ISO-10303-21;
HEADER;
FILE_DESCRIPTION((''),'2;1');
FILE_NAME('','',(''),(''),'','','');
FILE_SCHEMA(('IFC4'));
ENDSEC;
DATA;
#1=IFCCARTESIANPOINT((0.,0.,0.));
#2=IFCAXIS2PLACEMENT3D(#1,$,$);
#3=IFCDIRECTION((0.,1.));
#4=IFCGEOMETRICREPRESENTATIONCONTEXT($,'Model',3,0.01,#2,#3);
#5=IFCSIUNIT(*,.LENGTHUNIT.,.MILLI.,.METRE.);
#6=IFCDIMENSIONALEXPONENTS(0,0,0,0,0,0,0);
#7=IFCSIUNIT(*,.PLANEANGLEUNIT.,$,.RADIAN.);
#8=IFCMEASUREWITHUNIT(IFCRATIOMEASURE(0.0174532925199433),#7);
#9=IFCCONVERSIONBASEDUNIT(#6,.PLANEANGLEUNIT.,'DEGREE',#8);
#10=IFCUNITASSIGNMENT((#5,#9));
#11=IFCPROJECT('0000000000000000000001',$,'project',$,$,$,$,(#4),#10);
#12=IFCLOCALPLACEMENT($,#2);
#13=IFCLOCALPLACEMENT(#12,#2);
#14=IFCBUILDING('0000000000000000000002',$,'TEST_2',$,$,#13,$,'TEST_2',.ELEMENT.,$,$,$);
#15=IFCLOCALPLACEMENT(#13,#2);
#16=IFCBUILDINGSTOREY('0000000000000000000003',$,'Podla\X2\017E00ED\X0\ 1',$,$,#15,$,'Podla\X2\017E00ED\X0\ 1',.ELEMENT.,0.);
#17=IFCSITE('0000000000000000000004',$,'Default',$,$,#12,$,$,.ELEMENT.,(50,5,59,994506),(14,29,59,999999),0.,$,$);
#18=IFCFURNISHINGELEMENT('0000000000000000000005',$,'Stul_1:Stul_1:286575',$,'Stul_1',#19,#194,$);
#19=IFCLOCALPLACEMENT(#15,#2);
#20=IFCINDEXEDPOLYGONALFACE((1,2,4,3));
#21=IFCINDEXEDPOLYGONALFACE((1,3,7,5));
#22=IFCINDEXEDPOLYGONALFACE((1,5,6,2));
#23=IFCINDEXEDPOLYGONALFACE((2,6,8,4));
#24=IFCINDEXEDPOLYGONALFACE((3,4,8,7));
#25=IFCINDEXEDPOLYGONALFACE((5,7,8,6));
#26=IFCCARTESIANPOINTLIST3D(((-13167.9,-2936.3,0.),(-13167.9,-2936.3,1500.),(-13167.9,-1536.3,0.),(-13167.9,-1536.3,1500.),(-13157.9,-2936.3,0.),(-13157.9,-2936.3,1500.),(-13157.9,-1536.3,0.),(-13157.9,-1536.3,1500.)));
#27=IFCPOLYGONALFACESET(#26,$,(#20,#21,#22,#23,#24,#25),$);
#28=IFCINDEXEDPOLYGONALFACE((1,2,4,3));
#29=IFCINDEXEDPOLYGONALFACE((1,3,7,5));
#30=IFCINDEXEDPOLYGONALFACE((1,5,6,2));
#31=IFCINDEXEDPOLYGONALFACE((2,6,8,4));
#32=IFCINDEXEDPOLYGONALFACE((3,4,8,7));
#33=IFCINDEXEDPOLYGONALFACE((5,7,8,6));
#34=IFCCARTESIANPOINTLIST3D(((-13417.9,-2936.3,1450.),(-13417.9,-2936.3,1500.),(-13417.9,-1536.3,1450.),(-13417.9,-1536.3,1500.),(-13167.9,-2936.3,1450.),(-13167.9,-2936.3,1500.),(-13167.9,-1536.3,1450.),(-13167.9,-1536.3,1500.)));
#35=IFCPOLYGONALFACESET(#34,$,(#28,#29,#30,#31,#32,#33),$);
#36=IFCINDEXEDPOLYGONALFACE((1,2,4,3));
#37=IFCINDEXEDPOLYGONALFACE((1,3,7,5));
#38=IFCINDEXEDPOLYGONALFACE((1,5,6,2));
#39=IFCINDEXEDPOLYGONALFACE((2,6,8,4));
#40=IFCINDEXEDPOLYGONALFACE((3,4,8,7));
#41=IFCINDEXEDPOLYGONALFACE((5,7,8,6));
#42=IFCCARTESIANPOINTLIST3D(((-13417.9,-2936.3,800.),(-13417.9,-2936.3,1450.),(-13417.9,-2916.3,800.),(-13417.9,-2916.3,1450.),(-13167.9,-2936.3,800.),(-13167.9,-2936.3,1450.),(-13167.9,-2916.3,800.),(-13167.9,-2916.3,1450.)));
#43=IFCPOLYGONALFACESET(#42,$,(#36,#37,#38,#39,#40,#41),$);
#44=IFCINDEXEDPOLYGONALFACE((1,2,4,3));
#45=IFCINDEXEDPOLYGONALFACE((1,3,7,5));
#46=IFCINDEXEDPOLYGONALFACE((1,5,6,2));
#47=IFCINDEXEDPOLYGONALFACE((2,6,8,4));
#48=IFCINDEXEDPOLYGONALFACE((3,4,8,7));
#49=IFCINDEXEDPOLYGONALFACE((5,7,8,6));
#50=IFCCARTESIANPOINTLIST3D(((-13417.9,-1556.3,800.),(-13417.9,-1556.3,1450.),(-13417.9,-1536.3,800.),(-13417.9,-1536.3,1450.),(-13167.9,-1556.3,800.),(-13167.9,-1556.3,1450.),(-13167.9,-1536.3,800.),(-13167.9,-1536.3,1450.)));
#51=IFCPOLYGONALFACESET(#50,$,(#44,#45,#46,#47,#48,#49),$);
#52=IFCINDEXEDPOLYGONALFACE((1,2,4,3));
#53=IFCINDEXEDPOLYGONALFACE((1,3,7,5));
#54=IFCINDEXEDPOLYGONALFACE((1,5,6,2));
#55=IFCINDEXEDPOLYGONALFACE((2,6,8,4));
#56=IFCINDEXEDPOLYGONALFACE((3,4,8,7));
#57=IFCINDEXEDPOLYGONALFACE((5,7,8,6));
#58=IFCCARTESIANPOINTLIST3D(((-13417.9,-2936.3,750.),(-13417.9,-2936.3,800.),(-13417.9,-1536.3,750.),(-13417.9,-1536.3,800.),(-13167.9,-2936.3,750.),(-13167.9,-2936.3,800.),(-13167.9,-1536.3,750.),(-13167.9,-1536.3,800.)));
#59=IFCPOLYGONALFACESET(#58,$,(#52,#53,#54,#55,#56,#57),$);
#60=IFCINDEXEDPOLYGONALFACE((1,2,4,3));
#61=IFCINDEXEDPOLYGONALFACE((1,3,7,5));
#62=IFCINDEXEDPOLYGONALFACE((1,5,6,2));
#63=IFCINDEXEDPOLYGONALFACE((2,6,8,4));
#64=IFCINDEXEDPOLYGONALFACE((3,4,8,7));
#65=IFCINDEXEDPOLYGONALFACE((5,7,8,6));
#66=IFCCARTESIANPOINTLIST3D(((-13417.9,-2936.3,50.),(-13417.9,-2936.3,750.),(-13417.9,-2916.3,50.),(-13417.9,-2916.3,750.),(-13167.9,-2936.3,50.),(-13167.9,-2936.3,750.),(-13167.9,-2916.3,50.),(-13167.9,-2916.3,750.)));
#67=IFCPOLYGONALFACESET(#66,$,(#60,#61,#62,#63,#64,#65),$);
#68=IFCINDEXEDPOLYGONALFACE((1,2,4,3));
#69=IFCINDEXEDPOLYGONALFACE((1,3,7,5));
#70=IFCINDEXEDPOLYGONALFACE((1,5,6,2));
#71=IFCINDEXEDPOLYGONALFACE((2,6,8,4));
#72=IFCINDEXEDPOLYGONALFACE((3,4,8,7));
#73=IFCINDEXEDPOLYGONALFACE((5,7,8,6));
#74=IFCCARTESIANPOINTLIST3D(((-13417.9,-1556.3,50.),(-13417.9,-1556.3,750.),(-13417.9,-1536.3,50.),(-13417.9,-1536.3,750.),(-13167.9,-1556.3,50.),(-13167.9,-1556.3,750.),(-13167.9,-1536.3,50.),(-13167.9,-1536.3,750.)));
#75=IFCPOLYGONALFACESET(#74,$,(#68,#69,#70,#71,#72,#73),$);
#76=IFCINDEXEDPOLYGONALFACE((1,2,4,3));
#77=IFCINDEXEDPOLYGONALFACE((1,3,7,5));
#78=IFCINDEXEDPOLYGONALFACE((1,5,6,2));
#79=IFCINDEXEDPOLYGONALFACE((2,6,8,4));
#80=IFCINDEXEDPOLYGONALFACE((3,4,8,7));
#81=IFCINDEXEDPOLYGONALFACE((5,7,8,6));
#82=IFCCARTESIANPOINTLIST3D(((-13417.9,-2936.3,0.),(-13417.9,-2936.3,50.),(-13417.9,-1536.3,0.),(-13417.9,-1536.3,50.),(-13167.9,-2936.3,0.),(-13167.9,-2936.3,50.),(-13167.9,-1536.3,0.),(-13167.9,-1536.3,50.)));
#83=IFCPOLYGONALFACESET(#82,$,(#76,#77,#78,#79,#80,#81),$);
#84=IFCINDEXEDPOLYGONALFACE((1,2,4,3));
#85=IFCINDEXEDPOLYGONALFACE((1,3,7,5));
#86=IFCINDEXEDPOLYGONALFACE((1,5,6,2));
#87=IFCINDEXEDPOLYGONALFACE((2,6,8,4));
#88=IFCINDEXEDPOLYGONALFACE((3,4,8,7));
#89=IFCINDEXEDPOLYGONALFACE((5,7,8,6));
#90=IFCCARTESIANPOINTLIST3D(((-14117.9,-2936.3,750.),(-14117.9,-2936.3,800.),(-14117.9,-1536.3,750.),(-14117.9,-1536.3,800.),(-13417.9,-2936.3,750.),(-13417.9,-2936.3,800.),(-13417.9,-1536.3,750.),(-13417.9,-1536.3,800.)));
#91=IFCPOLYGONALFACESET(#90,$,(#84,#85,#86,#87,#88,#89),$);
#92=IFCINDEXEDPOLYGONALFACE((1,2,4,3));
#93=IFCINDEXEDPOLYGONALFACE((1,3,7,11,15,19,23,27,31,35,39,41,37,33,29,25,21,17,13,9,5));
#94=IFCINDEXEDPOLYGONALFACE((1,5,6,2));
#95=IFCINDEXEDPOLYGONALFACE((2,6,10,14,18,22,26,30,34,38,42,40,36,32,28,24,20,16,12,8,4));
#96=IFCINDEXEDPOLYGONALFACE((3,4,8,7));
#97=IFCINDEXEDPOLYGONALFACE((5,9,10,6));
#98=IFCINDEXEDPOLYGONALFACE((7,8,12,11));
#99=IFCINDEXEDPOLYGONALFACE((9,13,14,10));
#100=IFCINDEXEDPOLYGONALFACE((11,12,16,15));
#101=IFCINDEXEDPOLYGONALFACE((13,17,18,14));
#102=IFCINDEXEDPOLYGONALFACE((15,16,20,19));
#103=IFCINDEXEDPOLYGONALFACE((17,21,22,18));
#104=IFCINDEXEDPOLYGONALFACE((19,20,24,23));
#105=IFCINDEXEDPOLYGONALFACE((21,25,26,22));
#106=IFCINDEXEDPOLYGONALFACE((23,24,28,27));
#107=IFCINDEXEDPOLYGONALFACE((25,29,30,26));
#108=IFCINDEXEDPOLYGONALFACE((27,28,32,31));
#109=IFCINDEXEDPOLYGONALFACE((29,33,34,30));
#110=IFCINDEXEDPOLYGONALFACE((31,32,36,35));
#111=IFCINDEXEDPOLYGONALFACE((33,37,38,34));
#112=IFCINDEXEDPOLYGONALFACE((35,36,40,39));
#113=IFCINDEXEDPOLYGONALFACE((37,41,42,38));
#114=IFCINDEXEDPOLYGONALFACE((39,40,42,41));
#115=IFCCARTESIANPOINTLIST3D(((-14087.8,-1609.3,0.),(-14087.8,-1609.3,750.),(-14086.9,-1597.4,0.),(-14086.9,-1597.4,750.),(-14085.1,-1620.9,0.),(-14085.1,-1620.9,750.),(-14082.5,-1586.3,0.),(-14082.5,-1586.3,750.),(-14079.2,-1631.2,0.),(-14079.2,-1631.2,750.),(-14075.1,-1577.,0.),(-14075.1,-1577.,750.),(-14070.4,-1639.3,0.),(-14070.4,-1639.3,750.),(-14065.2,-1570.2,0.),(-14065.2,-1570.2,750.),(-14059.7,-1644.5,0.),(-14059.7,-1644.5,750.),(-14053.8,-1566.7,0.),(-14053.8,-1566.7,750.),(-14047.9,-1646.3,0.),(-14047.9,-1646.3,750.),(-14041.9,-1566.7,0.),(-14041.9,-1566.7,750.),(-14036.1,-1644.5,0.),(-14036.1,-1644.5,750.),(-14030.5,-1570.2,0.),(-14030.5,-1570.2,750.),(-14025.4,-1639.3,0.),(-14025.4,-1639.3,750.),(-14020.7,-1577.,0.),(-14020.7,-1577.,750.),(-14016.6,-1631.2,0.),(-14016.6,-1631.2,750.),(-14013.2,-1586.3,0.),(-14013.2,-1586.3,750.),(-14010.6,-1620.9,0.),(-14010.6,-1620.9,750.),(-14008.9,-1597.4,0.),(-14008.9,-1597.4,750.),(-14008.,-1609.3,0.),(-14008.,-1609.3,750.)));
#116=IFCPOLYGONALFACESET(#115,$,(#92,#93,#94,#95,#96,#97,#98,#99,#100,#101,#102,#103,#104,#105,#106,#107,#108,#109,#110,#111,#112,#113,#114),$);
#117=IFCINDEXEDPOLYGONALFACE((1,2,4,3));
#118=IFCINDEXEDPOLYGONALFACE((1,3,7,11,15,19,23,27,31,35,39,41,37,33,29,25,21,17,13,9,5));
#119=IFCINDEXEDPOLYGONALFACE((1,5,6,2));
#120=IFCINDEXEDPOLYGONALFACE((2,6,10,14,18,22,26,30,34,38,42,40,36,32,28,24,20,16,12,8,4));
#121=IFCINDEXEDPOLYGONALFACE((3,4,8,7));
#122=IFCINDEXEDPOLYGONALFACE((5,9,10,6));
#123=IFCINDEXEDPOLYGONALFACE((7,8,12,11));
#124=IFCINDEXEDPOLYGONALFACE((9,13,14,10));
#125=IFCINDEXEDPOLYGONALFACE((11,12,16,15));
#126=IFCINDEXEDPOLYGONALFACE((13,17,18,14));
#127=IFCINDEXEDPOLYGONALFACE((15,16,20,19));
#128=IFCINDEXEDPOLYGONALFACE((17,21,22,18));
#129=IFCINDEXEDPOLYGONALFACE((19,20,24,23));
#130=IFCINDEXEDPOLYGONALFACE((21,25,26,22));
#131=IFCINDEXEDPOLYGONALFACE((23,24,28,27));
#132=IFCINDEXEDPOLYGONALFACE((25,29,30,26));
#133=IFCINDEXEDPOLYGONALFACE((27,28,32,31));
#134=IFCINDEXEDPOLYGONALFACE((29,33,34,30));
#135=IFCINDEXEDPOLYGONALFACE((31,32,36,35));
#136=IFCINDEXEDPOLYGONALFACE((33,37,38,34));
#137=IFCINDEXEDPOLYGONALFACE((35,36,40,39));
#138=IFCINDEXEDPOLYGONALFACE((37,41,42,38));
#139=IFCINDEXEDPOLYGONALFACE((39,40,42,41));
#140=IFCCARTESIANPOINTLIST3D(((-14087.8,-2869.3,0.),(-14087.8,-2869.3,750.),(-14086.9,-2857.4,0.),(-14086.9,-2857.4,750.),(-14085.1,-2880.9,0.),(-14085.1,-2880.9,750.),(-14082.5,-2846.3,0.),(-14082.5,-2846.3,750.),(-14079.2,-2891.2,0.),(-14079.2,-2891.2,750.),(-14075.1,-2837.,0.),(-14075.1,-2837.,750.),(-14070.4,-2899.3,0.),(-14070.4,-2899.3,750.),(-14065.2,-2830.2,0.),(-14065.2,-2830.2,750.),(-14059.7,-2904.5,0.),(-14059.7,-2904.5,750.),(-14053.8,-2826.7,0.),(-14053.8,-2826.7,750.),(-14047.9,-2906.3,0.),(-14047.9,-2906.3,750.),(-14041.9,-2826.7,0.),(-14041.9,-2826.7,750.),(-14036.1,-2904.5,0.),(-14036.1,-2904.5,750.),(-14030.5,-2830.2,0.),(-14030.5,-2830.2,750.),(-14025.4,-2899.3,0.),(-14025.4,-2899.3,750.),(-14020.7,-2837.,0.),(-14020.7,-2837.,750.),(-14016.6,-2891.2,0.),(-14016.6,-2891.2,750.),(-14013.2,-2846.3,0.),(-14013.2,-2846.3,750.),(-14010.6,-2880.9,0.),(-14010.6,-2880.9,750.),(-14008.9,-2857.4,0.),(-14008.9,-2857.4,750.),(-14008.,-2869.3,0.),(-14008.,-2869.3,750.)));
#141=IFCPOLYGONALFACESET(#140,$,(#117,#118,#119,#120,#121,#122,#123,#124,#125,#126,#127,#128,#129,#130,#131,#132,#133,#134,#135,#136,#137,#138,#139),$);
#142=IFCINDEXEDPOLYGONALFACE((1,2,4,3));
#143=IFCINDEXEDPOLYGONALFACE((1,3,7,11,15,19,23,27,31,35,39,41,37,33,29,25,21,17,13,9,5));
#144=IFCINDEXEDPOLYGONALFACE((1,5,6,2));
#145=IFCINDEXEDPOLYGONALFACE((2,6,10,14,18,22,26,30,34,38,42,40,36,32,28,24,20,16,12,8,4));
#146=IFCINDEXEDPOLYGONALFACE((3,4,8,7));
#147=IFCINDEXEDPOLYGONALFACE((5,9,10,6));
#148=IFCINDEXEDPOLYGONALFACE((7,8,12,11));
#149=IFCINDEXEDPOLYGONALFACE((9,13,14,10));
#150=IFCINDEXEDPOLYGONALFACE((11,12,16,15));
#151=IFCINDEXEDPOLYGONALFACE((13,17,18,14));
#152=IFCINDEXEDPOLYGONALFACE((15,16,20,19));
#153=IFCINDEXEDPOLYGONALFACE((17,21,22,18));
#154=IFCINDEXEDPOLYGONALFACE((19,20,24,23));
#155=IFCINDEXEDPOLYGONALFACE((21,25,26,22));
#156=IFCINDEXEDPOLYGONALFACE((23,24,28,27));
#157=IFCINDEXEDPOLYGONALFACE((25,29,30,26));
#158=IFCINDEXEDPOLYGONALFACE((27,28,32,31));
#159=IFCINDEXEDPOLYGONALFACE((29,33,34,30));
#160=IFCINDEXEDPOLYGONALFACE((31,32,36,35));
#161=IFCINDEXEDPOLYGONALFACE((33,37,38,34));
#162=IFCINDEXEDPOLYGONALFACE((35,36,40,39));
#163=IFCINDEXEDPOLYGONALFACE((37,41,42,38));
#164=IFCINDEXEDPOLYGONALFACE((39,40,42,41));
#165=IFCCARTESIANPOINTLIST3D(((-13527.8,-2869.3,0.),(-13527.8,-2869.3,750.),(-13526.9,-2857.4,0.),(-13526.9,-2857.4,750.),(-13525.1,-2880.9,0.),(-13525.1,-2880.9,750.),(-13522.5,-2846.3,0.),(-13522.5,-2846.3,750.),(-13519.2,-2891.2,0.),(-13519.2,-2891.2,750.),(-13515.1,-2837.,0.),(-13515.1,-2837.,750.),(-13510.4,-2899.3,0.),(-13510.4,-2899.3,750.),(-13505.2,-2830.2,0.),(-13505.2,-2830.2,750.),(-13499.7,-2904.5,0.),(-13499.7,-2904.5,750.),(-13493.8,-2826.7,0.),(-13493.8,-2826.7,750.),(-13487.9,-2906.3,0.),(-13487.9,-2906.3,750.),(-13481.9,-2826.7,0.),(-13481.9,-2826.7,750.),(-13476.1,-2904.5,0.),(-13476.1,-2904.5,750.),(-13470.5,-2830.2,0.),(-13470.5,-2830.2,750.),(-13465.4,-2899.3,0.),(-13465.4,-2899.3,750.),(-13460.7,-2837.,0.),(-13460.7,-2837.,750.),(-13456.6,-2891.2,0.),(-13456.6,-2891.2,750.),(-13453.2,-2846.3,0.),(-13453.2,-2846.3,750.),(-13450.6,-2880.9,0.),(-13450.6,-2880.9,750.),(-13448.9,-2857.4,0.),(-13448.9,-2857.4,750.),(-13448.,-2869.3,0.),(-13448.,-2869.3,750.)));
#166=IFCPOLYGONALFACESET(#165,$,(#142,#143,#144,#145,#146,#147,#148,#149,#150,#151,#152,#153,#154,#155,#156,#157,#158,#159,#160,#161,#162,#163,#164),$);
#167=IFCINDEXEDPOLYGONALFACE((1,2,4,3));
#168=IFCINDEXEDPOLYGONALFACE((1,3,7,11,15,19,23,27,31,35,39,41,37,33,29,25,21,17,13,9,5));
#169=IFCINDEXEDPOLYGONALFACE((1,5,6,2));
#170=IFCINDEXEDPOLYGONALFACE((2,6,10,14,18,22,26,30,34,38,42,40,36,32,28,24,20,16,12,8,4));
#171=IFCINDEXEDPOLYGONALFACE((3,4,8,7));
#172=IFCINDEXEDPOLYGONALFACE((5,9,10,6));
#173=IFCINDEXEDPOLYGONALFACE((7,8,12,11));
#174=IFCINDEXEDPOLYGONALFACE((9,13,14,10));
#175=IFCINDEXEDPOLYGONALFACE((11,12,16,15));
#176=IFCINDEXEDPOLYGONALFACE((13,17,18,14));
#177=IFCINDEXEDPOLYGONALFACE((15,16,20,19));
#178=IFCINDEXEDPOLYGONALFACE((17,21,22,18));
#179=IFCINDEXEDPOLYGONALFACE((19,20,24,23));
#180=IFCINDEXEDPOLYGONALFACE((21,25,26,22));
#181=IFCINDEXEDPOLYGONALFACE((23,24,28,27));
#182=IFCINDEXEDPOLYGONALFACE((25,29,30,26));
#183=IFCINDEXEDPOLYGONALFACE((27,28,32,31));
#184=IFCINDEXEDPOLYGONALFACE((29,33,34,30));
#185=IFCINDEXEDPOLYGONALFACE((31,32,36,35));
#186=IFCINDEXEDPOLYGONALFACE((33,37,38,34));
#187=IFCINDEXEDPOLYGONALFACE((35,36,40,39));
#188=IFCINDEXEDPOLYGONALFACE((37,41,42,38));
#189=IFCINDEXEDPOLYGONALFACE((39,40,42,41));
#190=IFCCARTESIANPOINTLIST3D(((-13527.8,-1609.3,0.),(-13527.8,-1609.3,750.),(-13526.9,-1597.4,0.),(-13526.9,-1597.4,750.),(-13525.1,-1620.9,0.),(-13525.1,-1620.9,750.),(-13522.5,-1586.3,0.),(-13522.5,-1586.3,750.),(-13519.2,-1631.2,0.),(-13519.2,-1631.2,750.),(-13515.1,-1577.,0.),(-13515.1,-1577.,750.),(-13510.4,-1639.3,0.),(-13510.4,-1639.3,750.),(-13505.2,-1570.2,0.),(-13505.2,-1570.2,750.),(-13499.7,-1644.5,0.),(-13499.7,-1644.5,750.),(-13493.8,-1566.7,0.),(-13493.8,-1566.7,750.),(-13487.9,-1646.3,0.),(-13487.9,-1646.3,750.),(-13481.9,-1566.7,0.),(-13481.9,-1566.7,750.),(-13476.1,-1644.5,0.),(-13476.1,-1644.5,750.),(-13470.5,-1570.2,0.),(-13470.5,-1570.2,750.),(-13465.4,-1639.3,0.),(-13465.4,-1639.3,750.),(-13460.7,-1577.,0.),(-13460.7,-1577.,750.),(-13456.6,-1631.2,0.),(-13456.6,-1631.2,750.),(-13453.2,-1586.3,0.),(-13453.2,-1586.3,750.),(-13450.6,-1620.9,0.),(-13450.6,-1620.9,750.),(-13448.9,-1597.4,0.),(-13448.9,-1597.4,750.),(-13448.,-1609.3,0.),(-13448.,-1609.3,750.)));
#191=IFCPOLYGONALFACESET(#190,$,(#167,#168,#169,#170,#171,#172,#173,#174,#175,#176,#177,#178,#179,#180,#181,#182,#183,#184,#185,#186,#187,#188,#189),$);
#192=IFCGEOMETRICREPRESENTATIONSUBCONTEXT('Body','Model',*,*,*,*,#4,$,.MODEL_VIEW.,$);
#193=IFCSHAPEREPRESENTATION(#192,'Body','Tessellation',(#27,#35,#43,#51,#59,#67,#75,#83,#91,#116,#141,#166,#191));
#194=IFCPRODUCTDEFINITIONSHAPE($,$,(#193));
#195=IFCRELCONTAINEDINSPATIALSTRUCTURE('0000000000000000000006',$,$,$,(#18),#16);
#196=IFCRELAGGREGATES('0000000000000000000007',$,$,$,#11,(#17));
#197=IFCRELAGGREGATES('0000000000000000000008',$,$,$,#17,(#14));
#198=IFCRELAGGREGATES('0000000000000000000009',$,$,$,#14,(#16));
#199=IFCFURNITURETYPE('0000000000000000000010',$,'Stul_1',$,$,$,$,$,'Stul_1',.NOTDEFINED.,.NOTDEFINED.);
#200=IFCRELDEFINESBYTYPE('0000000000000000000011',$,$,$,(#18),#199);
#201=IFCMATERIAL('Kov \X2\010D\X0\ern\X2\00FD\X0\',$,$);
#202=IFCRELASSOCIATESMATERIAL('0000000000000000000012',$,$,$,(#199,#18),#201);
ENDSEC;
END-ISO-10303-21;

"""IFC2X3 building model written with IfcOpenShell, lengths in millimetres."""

from ifc_helpers import new_model, entity, si_unit, converted_unit, direction, frame, frame_2d, origin, origin_2d_with_axis, place, context, subcontext, project, spatial, rectangle, circle, extrude, source, transform, mapped, material, type_object, type_shapes, element, save


model = new_model("IFC2X3")

# Units and contexts
model_context = context("Model", 3, precision=0.01, world=origin(), true_north=direction((0.0, 1.0)))
body_context = subcontext(model_context, "Body", "Model", "MODEL_VIEW")
ifc_project = project(units=[si_unit("LENGTHUNIT", "METRE", prefix="MILLI"), converted_unit("PLANEANGLEUNIT", "DEGREE", entity("IfcRatioMeasure", 0.0174532925199433), si_unit("PLANEANGLEUNIT", "RADIAN"), dimensions=[0, 0, 0, 0, 0, 0, 0])], contexts=[model_context])

# Site, building, storey
site_placement = place(None, origin())
site = spatial("IfcSite", under=ifc_project, at=site_placement, Name="Default", CompositionType="ELEMENT", RefLatitude=(50, 5, 59, 994506), RefLongitude=(14, 29, 59, 999999), RefElevation=0.0)
building_placement = place(site_placement, origin())
building = spatial("IfcBuilding", under=site, at=building_placement, Name="TEST_2", LongName="TEST_2", CompositionType="ELEMENT")
storey_placement = place(building_placement, origin())
storey = spatial("IfcBuildingStorey", under=building, at=storey_placement, Name="Podlaží 1", LongName="Podlaží 1", CompositionType="ELEMENT", Elevation=0.0)

# Furnishing element
ifc_material_1 = material(Name="Kov černý")
furniture_type = type_object("IfcFurnitureType", Name="Stul_1", ElementType="Stul_1", material=ifc_material_1)
shared_shape_1 = source(origin(), body_context, "Body", "SweptSolid", [
    extrude(rectangle(XDim=1400.0, YDim=10.0, at=origin_2d_with_axis()), frame((0.0, 605.0, 0.0), z_axis=(0.0, 0.0, 1.0), x_axis=(-1.0, 0.0, 0.0)), (0.0, 0.0, 1.0), 1500.0),
    extrude(rectangle(XDim=1400.0, YDim=250.0, at=frame_2d((0.0, 0.0), x_axis=(1.0, 0.0))), frame((0.0, 475.0, 1450.0), z_axis=(0.0, 0.0, 1.0), x_axis=(-1.0, 0.0, 0.0)), (0.0, 0.0, 1.0), 50.0),
    extrude(rectangle(XDim=20.0, YDim=250.0, at=origin_2d_with_axis()), frame((690.0, 475.0, 800.0), z_axis=(0.0, 0.0, 1.0), x_axis=(-1.0, 0.0, 0.0)), (0.0, 0.0, 1.0), 650.0),
    extrude(rectangle(XDim=20.0, YDim=250.0, at=frame_2d((0.0, 0.0), x_axis=(1.0, 0.0))), frame((-690.0, 475.0, 800.0), z_axis=(0.0, 0.0, 1.0), x_axis=(-1.0, 0.0, 0.0)), (0.0, 0.0, 1.0), 650.0),
    extrude(rectangle(XDim=1400.0, YDim=250.0, at=origin_2d_with_axis()), frame((0.0, 475.0, 750.0), z_axis=(0.0, 0.0, 1.0), x_axis=(-1.0, 0.0, 0.0)), (0.0, 0.0, 1.0), 50.0),
    extrude(rectangle(XDim=20.0, YDim=250.0, at=origin_2d_with_axis()), frame((690.0, 475.0, 50.0), z_axis=(0.0, 0.0, 1.0), x_axis=(-1.0, 0.0, 0.0)), (0.0, 0.0, 1.0), 700.0),
    extrude(rectangle(XDim=20.0, YDim=250.0, at=frame_2d((0.0, 0.0), x_axis=(1.0, 0.0))), frame((-690.0, 475.0, 50.0), z_axis=(0.0, 0.0, 1.0), x_axis=(-1.0, 0.0, 0.0)), (0.0, 0.0, 1.0), 700.0),
    extrude(rectangle(XDim=1400.0, YDim=250.0, at=origin_2d_with_axis()), frame((0.0, 475.0, 0.0), z_axis=(0.0, 0.0, 1.0), x_axis=(-1.0, 0.0, 0.0)), (0.0, 0.0, 1.0), 50.0),
    extrude(rectangle(XDim=1400.0, YDim=700.0, at=origin_2d_with_axis()), frame((0.0, 0.0, 750.0), z_axis=(0.0, 0.0, 1.0), x_axis=(-1.0, 0.0, 0.0)), (0.0, 0.0, 1.0), 50.0),
    extrude(circle(Radius=40.0, at=frame_2d((0.0, 0.0), x_axis=(1.0, 0.0))), frame((-630.0, -280.0, 0.0)), (0.0, 0.0, 1.0), 750.0),
    extrude(circle(Radius=40.0, at=frame_2d((0.0, 0.0), x_axis=(1.0, 0.0))), frame((630.0, -280.0, 0.0)), (0.0, 0.0, 1.0), 750.0),
    extrude(circle(Radius=40.0, at=frame_2d((0.0, 0.0), x_axis=(1.0, 0.0))), frame((630.0, 280.0, 0.0)), (0.0, 0.0, 1.0), 750.0),
    extrude(circle(Radius=40.0, at=frame_2d((0.0, 0.0), x_axis=(1.0, 0.0))), frame((-630.0, 280.0, 0.0)), (0.0, 0.0, 1.0), 750.0),
])
type_shapes(furniture_type, [shared_shape_1])
for number, where, z_axis, x_axis, name in (
    (1, (-13767.9, -2236.3, 0.0), (0.0, 0.0, 1.0), (0.0, -1.0, 0.0), "Stul_1:Stul_1:286575"),
):
    element("IfcFurnishingElement", number, at=place(storey_placement, frame(where, z_axis=z_axis, x_axis=x_axis)), inside=storey, type_object=furniture_type, material=ifc_material_1, Name=name, ObjectType="Stul_1", context=body_context, shape_type="MappedRepresentation", body=[
        mapped(shared_shape_1, transform((0.0, 0.0, 0.0), scale=1.0)),
    ])

save(model, "model.ifc")
